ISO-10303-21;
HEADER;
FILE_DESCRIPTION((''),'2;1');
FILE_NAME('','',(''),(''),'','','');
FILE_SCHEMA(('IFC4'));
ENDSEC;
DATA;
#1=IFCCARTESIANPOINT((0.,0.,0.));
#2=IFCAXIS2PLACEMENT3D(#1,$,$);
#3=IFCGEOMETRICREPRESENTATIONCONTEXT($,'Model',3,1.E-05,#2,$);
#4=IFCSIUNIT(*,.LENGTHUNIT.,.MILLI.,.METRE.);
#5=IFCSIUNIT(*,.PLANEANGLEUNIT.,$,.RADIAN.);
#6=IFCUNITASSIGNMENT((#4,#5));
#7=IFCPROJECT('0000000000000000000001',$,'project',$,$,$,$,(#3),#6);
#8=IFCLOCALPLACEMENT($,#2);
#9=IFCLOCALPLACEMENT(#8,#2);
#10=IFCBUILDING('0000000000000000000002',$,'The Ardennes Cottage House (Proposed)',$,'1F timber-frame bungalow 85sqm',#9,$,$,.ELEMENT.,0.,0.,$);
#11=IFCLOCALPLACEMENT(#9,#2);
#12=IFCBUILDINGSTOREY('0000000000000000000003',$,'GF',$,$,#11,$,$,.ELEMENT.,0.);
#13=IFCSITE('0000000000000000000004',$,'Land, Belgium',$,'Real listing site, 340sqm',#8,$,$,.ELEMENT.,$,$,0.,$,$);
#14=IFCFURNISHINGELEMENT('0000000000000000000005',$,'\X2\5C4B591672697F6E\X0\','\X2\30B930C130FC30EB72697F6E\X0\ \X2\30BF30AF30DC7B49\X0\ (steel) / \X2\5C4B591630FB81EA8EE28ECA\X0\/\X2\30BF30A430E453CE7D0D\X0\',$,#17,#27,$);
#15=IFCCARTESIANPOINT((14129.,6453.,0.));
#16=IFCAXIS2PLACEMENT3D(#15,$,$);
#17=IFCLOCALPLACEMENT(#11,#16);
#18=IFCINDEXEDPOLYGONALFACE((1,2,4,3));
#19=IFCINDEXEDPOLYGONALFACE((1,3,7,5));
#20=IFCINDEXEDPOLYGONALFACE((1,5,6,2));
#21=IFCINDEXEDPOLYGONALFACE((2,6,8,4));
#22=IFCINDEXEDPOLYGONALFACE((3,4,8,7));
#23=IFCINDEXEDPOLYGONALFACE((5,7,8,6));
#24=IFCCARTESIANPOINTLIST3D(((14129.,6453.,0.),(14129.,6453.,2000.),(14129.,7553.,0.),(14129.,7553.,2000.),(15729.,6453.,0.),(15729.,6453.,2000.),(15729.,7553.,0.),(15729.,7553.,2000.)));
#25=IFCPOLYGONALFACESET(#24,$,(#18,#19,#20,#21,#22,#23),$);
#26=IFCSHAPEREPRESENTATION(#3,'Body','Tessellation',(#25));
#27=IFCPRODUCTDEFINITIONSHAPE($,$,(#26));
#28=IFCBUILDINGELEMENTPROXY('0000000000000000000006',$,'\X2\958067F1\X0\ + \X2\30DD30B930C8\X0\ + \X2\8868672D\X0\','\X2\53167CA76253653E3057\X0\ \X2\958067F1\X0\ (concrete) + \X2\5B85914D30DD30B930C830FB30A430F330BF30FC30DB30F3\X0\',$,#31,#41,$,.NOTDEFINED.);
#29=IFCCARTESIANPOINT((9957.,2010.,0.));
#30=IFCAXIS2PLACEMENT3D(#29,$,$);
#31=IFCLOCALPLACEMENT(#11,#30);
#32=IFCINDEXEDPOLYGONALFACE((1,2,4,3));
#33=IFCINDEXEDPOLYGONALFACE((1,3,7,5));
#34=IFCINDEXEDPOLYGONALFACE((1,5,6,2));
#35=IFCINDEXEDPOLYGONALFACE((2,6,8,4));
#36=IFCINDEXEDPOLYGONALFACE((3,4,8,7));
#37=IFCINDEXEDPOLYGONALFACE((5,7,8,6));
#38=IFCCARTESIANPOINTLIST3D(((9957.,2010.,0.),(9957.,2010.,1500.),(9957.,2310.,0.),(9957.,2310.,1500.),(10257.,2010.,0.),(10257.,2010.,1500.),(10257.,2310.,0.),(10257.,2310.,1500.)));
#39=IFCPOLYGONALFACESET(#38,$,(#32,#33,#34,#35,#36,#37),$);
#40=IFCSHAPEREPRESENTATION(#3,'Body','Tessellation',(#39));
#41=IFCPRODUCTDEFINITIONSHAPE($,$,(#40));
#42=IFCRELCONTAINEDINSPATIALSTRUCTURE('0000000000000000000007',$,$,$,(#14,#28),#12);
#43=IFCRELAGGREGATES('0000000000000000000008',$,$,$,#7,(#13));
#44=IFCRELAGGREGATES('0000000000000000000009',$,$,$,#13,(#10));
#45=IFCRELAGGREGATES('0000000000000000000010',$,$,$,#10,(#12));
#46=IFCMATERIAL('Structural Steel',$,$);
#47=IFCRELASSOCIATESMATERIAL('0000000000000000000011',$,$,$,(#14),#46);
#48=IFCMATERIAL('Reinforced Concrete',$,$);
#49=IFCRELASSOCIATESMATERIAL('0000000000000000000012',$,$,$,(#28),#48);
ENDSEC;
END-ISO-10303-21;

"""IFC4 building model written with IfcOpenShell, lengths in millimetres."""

from ifc_helpers import new_model, si_unit, frame, frame_2d, origin, place, context, project, spatial, rectangle, extrude, material, element, save


model = new_model("IFC4")

# Units and contexts
model_context = context("Model", 3, precision=1e-05, world=origin())
ifc_project = project(units=[si_unit("LENGTHUNIT", "METRE", prefix="MILLI"), si_unit("PLANEANGLEUNIT", "RADIAN")], contexts=[model_context])

# Site, building, storey
site_placement = place(None, origin())
site = spatial("IfcSite", under=ifc_project, at=site_placement, Name="Land, Belgium", ObjectType="Real listing site, 340sqm", CompositionType="ELEMENT", RefElevation=0.0)
building_placement = place(site_placement, origin())
building = spatial("IfcBuilding", under=site, at=building_placement, Name="The Ardennes Cottage House (Proposed)", ObjectType="1F timber-frame bungalow 85sqm", CompositionType="ELEMENT", ElevationOfRefHeight=0.0, ElevationOfTerrain=0.0)
storey_placement = place(building_placement, origin())
storey = spatial("IfcBuildingStorey", under=building, at=storey_placement, Name="GF", CompositionType="ELEMENT", Elevation=0.0)

# Shared definitions
ifc_material_1 = material(Name="Reinforced Concrete")

# Shared definitions
ifc_material_2 = material(Name="Structural Steel")

# Furnishing element
furnishing_1_placement = place(storey_placement, frame((14129.0, 6453.0, 0.0)))
element("IfcFurnishingElement", 1, at=furnishing_1_placement, inside=storey, material=ifc_material_2, Name="屋外物置", Description="スチール物置 タクボ等 (steel) / 屋外・自転車/タイヤ収納", context=model_context, shape_type="SweptSolid", body=[
    extrude(rectangle(XDim=1600.0, YDim=1100.0, at=frame_2d((800.0, 550.0))), frame((14129.0, 6453.0, 0.0)), (0.0, 0.0, 1.0), 2000.0),
])

# Building element proxy
proxy_placement = place(storey_placement, frame((9957.0, 2010.0, 0.0)))
element("IfcBuildingElementProxy", 2, at=proxy_placement, inside=storey, material=ifc_material_1, Name="門柱 + ポスト + 表札", Description="化粧打放し 門柱 (concrete) + 宅配ポスト・インターホン", PredefinedType="NOTDEFINED", context=model_context, shape_type="SweptSolid", body=[
    extrude(rectangle(XDim=300.0, YDim=300.0, at=frame_2d((150.0, 150.0))), frame((9957.0, 2010.0, 0.0)), (0.0, 0.0, 1.0), 1500.0),
])

save(model, "model.ifc")
